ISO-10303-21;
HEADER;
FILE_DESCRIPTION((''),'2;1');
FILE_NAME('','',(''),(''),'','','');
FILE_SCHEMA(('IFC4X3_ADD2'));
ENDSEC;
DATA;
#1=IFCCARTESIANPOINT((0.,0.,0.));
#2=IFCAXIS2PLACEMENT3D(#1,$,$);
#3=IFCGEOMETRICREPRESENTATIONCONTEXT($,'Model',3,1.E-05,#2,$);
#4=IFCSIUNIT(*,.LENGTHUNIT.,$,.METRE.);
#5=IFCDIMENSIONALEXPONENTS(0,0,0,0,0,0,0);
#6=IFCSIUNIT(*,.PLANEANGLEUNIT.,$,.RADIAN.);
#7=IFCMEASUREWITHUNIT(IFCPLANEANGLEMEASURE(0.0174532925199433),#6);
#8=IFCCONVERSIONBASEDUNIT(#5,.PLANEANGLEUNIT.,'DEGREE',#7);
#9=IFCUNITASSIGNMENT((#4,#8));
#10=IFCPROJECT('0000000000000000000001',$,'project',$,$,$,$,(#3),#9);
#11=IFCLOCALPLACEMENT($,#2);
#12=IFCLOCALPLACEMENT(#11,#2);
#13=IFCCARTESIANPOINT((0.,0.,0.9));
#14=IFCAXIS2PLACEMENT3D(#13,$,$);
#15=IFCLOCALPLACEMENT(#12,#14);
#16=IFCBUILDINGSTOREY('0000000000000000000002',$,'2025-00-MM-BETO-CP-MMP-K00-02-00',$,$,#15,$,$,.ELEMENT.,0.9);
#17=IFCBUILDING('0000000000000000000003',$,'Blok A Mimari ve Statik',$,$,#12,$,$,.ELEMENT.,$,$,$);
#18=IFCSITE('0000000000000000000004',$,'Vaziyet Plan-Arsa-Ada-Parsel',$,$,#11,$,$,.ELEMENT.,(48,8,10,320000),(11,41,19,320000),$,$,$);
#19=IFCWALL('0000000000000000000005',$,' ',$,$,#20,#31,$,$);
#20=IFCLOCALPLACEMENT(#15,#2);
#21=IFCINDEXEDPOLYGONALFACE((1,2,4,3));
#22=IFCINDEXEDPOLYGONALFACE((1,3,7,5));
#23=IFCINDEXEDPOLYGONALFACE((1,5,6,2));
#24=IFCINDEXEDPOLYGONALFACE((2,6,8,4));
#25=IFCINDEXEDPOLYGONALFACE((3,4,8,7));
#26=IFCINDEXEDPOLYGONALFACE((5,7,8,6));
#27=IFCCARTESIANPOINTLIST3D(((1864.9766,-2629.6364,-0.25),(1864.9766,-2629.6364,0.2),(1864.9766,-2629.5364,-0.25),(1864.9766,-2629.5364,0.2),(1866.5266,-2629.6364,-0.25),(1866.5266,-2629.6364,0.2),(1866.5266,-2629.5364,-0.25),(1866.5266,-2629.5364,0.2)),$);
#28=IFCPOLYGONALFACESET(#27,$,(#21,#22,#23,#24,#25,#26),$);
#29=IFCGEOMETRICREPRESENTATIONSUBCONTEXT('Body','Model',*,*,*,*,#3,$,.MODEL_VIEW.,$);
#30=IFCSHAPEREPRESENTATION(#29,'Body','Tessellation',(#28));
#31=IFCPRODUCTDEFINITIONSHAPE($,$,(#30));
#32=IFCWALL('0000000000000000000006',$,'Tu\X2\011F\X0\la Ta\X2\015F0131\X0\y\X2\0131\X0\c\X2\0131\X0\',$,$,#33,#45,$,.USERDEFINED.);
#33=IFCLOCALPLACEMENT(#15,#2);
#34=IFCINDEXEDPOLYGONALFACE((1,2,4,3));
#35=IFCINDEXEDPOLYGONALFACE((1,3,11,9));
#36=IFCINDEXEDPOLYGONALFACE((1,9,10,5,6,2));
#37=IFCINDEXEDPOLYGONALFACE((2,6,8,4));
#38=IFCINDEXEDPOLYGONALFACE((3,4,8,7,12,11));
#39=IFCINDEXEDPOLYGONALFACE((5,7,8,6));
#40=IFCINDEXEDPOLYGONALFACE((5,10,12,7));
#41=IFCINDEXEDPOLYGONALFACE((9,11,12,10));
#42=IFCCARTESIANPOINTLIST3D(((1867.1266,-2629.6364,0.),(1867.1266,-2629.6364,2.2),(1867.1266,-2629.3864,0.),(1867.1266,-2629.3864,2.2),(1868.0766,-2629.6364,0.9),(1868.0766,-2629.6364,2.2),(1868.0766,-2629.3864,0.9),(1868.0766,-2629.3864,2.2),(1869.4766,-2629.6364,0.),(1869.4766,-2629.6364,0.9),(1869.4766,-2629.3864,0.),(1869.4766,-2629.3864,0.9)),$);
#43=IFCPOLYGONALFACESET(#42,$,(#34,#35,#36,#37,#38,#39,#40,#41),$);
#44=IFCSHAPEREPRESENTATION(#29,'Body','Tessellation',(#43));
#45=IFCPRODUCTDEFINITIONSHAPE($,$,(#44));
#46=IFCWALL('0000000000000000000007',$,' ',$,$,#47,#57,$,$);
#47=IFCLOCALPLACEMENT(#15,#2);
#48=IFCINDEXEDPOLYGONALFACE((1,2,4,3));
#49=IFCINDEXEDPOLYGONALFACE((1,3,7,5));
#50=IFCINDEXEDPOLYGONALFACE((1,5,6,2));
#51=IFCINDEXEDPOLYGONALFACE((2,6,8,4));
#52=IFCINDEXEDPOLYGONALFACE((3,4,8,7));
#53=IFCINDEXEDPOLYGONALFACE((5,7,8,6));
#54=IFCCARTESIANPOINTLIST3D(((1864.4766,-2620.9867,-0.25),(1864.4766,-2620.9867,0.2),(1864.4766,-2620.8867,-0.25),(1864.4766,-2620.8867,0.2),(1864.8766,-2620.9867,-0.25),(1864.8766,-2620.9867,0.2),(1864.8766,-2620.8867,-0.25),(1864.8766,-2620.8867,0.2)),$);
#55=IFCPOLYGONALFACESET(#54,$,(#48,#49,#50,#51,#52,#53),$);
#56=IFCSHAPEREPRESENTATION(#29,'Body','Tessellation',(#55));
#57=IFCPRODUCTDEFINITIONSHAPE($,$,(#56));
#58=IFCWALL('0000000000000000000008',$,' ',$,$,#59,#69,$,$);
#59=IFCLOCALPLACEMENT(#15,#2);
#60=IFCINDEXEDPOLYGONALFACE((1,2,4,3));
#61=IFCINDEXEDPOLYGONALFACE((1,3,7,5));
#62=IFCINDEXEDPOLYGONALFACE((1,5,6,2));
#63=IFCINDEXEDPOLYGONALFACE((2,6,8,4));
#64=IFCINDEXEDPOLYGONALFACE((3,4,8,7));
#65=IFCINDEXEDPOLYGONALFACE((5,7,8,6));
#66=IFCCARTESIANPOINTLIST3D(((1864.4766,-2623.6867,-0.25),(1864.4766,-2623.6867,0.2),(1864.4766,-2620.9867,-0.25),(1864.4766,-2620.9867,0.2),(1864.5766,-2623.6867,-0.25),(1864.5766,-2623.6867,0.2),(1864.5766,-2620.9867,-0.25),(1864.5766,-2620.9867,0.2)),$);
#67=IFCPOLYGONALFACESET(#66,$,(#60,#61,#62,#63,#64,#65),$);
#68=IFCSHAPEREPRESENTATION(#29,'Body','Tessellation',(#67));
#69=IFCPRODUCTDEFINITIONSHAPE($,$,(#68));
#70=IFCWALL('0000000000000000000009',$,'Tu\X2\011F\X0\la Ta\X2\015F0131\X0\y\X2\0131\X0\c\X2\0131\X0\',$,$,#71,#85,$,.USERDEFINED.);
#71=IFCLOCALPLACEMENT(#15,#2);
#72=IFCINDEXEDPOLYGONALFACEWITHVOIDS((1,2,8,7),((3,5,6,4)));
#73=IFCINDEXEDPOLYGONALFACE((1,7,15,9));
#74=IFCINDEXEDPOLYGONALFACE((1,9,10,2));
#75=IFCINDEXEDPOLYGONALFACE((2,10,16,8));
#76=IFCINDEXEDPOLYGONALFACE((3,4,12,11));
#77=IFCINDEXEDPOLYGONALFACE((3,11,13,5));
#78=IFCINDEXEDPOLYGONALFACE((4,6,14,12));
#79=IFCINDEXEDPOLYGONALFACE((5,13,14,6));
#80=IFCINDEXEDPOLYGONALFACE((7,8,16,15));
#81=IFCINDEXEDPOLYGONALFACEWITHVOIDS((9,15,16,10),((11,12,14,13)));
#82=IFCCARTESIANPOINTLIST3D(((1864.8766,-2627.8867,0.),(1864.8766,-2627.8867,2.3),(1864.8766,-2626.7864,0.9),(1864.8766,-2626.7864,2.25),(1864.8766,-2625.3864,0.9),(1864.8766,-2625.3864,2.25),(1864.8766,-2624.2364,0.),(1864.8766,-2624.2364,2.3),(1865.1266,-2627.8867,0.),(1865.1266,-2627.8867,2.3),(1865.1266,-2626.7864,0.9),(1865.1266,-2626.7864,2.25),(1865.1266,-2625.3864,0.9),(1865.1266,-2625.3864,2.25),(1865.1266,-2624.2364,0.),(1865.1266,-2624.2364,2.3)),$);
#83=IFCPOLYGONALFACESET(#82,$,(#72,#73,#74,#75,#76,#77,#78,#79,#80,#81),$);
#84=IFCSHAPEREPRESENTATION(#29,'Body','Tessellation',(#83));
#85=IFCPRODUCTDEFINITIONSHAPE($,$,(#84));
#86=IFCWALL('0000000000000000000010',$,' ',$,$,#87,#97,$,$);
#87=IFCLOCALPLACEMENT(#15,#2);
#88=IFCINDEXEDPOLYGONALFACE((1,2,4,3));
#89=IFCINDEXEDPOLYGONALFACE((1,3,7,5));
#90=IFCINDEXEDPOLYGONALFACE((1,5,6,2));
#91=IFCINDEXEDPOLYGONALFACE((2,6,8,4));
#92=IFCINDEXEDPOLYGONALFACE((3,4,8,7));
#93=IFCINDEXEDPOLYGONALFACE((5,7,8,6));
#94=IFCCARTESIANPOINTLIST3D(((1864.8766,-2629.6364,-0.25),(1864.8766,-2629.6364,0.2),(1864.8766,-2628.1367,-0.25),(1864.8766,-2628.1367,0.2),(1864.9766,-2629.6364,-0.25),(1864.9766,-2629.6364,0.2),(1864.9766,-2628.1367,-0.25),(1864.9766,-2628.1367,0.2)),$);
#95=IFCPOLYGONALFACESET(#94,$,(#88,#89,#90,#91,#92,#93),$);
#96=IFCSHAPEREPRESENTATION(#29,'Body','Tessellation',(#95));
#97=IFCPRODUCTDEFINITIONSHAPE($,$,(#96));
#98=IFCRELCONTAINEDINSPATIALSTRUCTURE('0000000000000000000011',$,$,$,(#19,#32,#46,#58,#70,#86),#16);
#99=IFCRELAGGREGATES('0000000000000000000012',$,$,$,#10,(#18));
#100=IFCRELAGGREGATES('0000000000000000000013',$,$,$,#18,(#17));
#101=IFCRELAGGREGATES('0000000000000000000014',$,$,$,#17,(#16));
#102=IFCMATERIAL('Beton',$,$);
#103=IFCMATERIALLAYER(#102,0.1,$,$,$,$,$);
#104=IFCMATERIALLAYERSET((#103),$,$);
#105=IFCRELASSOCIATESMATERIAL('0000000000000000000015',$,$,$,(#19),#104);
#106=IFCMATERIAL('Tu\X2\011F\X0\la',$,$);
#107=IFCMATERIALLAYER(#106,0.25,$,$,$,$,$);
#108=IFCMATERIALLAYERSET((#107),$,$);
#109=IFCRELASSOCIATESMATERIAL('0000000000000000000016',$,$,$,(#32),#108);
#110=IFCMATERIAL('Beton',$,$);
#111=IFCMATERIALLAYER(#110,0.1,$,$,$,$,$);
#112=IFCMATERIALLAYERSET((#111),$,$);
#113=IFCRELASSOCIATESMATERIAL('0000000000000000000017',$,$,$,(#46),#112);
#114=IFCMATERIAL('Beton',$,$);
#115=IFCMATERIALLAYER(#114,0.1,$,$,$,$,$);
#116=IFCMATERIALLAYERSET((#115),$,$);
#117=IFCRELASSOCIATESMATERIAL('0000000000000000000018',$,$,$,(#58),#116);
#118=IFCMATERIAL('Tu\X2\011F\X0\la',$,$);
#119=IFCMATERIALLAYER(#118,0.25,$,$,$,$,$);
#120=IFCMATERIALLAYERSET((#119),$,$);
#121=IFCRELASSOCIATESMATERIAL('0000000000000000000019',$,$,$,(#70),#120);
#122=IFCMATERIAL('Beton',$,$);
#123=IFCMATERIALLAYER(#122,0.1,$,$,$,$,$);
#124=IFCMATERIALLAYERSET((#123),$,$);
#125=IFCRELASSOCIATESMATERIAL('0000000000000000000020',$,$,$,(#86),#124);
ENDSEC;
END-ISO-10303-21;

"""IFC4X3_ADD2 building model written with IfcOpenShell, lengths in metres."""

from ifc_helpers import new_model, entity, si_unit, converted_unit, frame, frame_2d, origin, origin_with_axes, place, context, subcontext, project, spatial, polyline, rectangle, outline, extrude, material, layer, layer_set, layer_usage, element, save


model = new_model("IFC4X3_ADD2")

# Units and contexts
model_context = context("Model", 3, precision=1e-05, world=origin())
body_context = subcontext(model_context, "Body", "Model", "MODEL_VIEW")
ifc_project = project(units=[si_unit("LENGTHUNIT", "METRE"), converted_unit("PLANEANGLEUNIT", "DEGREE", entity("IfcPlaneAngleMeasure", 0.0174532925199433), si_unit("PLANEANGLEUNIT", "RADIAN"), dimensions=[0, 0, 0, 0, 0, 0, 0])], contexts=[model_context])

# Site, building, storey
site_placement = place(None, origin())
site = spatial("IfcSite", under=ifc_project, at=site_placement, Name="Vaziyet Plan-Arsa-Ada-Parsel", CompositionType="ELEMENT", RefLatitude=(48, 8, 10, 320000), RefLongitude=(11, 41, 19, 320000))
building_placement = place(site_placement, origin())
building = spatial("IfcBuilding", under=site, at=building_placement, Name="Blok A Mimari ve Statik", CompositionType="ELEMENT")
storey_placement = place(building_placement, frame((0.0, 0.0, 0.9)))
storey = spatial("IfcBuildingStorey", under=building, at=storey_placement, Name="2025-00-MM-BETO-CP-MMP-K00-02-00", CompositionType="ELEMENT", Elevation=0.9)

# Wall
ifc_material_1 = material(Name="Beton")
ifc_layer_1 = layer(ifc_material_1, 0.1)
ifc_layer_set_1 = layer_set([ifc_layer_1])
ifc_layer_usage_1 = layer_usage(ifc_layer_set_1, "AXIS2", "POSITIVE", 0.0)
wall_1_placement = place(storey_placement, frame((1864.9766, -2629.6364, -0.25)))
element("IfcWall", 1, at=wall_1_placement, inside=storey, material=ifc_layer_usage_1, Name=" ", context=body_context, shape_type="SweptSolid", body=[
    extrude(rectangle(XDim=1.55, YDim=0.1, at=frame_2d((0.775, 0.05), x_axis=(1.0, 0.0))), origin_with_axes(), (0.0, 0.0, 1.0), 0.45),
])

# Wall, opening
ifc_material_2 = material(Name="Tuğla")
ifc_layer_2 = layer(ifc_material_2, 0.25)
ifc_layer_set_2 = layer_set([ifc_layer_2])
ifc_layer_usage_2 = layer_usage(ifc_layer_set_2, "AXIS2", "POSITIVE", 0.0)
wall_2_placement = place(storey_placement, frame((1867.1266, -2629.6364, 0.0)))
wall_2 = element("IfcWall", 2, at=wall_2_placement, inside=storey, material=ifc_layer_usage_2, Name="Tuğla Taşıyıcı", PredefinedType="USERDEFINED", context=body_context, shape_type="SweptSolid", body=[
    extrude(rectangle(XDim=2.35, YDim=0.25, at=frame_2d((1.175, 0.125), x_axis=(1.0, 0.0))), origin_with_axes(), (0.0, 0.0, 1.0), 2.2),
])
opening_1_placement = place(wall_2_placement, frame((0.95, 0.0, 0.9), z_axis=(0.0, 1.0, 0.0), x_axis=(0.0, 0.0, 1.0)))
element("IfcOpeningElement", 3, at=opening_1_placement, cuts=wall_2, PredefinedType="OPENING", context=body_context, shape_type="SweptSolid", body=[
    extrude(outline(polyline([(1.35, 1.4), (1.35, 0.0), (0.0, 0.0), (0.0, 1.4), (1.35, 1.4)])), origin_with_axes(), (0.0, 0.0, 1.0), 0.25),
])

# Walls
ifc_material_3 = material(Name="Beton")
ifc_layer_3 = layer(ifc_material_3, 0.1)
ifc_layer_set_3 = layer_set([ifc_layer_3])
ifc_layer_usage_3 = layer_usage(ifc_layer_set_3, "AXIS2", "POSITIVE", 0.0)
wall_3_placement = place(storey_placement, frame((1864.8766, -2620.8867, -0.25), z_axis=(0.0, 0.0, 1.0), x_axis=(-1.0, 0.0, 0.0)))
element("IfcWall", 4, at=wall_3_placement, inside=storey, material=ifc_layer_usage_3, Name=" ", context=body_context, shape_type="SweptSolid", body=[
    extrude(rectangle(XDim=0.4, YDim=0.1, at=frame_2d((0.2, 0.05), x_axis=(1.0, 0.0))), origin_with_axes(), (0.0, 0.0, 1.0), 0.45),
])
ifc_material_4 = material(Name="Beton")
ifc_layer_4 = layer(ifc_material_4, 0.1)
ifc_layer_set_4 = layer_set([ifc_layer_4])
ifc_layer_usage_4 = layer_usage(ifc_layer_set_4, "AXIS2", "POSITIVE", 0.0)
wall_4_placement = place(storey_placement, frame((1864.4766, -2620.9867, -0.25), z_axis=(0.0, 0.0, 1.0), x_axis=(0.0, -1.0, 0.0)))
element("IfcWall", 5, at=wall_4_placement, inside=storey, material=ifc_layer_usage_4, Name=" ", context=body_context, shape_type="SweptSolid", body=[
    extrude(rectangle(XDim=2.7, YDim=0.1, at=frame_2d((1.35, 0.05), x_axis=(1.0, 0.0))), origin_with_axes(), (0.0, 0.0, 1.0), 0.45),
])

# Wall, opening
ifc_material_5 = material(Name="Tuğla")
ifc_layer_5 = layer(ifc_material_5, 0.25)
ifc_layer_set_5 = layer_set([ifc_layer_5])
ifc_layer_usage_5 = layer_usage(ifc_layer_set_5, "AXIS2", "POSITIVE", 0.0)
wall_5_placement = place(storey_placement, frame((1864.8766, -2624.2364, 0.0), z_axis=(0.0, 0.0, 1.0), x_axis=(0.0, -1.0, 0.0)))
wall_5 = element("IfcWall", 6, at=wall_5_placement, inside=storey, material=ifc_layer_usage_5, Name="Tuğla Taşıyıcı", PredefinedType="USERDEFINED", context=body_context, shape_type="SweptSolid", body=[
    extrude(rectangle(XDim=3.6503, YDim=0.25, at=frame_2d((1.8252, 0.125), x_axis=(1.0, 0.0))), origin_with_axes(), (0.0, 0.0, 1.0), 2.3),
])
opening_2_placement = place(wall_5_placement, frame((1.15, 0.0, 0.9), z_axis=(0.0, 1.0, 0.0), x_axis=(0.0, 0.0, 1.0)))
element("IfcOpeningElement", 7, at=opening_2_placement, cuts=wall_5, PredefinedType="OPENING", context=body_context, shape_type="SweptSolid", body=[
    extrude(outline(polyline([(1.35, 1.4), (1.35, 0.0), (0.0, 0.0), (0.0, 1.4), (1.35, 1.4)])), origin_with_axes(), (0.0, 0.0, 1.0), 0.25),
])

# Wall
ifc_material_6 = material(Name="Beton")
ifc_layer_6 = layer(ifc_material_6, 0.1)
ifc_layer_set_6 = layer_set([ifc_layer_6])
ifc_layer_usage_6 = layer_usage(ifc_layer_set_6, "AXIS2", "POSITIVE", 0.0)
wall_6_placement = place(storey_placement, frame((1864.8766, -2628.1367, -0.25), z_axis=(0.0, 0.0, 1.0), x_axis=(0.0, -1.0, 0.0)))
element("IfcWall", 8, at=wall_6_placement, inside=storey, material=ifc_layer_usage_6, Name=" ", context=body_context, shape_type="SweptSolid", body=[
    extrude(rectangle(XDim=1.4997, YDim=0.1, at=frame_2d((0.7498, 0.05), x_axis=(1.0, 0.0))), origin_with_axes(), (0.0, 0.0, 1.0), 0.45),
])

save(model, "model.ifc")
